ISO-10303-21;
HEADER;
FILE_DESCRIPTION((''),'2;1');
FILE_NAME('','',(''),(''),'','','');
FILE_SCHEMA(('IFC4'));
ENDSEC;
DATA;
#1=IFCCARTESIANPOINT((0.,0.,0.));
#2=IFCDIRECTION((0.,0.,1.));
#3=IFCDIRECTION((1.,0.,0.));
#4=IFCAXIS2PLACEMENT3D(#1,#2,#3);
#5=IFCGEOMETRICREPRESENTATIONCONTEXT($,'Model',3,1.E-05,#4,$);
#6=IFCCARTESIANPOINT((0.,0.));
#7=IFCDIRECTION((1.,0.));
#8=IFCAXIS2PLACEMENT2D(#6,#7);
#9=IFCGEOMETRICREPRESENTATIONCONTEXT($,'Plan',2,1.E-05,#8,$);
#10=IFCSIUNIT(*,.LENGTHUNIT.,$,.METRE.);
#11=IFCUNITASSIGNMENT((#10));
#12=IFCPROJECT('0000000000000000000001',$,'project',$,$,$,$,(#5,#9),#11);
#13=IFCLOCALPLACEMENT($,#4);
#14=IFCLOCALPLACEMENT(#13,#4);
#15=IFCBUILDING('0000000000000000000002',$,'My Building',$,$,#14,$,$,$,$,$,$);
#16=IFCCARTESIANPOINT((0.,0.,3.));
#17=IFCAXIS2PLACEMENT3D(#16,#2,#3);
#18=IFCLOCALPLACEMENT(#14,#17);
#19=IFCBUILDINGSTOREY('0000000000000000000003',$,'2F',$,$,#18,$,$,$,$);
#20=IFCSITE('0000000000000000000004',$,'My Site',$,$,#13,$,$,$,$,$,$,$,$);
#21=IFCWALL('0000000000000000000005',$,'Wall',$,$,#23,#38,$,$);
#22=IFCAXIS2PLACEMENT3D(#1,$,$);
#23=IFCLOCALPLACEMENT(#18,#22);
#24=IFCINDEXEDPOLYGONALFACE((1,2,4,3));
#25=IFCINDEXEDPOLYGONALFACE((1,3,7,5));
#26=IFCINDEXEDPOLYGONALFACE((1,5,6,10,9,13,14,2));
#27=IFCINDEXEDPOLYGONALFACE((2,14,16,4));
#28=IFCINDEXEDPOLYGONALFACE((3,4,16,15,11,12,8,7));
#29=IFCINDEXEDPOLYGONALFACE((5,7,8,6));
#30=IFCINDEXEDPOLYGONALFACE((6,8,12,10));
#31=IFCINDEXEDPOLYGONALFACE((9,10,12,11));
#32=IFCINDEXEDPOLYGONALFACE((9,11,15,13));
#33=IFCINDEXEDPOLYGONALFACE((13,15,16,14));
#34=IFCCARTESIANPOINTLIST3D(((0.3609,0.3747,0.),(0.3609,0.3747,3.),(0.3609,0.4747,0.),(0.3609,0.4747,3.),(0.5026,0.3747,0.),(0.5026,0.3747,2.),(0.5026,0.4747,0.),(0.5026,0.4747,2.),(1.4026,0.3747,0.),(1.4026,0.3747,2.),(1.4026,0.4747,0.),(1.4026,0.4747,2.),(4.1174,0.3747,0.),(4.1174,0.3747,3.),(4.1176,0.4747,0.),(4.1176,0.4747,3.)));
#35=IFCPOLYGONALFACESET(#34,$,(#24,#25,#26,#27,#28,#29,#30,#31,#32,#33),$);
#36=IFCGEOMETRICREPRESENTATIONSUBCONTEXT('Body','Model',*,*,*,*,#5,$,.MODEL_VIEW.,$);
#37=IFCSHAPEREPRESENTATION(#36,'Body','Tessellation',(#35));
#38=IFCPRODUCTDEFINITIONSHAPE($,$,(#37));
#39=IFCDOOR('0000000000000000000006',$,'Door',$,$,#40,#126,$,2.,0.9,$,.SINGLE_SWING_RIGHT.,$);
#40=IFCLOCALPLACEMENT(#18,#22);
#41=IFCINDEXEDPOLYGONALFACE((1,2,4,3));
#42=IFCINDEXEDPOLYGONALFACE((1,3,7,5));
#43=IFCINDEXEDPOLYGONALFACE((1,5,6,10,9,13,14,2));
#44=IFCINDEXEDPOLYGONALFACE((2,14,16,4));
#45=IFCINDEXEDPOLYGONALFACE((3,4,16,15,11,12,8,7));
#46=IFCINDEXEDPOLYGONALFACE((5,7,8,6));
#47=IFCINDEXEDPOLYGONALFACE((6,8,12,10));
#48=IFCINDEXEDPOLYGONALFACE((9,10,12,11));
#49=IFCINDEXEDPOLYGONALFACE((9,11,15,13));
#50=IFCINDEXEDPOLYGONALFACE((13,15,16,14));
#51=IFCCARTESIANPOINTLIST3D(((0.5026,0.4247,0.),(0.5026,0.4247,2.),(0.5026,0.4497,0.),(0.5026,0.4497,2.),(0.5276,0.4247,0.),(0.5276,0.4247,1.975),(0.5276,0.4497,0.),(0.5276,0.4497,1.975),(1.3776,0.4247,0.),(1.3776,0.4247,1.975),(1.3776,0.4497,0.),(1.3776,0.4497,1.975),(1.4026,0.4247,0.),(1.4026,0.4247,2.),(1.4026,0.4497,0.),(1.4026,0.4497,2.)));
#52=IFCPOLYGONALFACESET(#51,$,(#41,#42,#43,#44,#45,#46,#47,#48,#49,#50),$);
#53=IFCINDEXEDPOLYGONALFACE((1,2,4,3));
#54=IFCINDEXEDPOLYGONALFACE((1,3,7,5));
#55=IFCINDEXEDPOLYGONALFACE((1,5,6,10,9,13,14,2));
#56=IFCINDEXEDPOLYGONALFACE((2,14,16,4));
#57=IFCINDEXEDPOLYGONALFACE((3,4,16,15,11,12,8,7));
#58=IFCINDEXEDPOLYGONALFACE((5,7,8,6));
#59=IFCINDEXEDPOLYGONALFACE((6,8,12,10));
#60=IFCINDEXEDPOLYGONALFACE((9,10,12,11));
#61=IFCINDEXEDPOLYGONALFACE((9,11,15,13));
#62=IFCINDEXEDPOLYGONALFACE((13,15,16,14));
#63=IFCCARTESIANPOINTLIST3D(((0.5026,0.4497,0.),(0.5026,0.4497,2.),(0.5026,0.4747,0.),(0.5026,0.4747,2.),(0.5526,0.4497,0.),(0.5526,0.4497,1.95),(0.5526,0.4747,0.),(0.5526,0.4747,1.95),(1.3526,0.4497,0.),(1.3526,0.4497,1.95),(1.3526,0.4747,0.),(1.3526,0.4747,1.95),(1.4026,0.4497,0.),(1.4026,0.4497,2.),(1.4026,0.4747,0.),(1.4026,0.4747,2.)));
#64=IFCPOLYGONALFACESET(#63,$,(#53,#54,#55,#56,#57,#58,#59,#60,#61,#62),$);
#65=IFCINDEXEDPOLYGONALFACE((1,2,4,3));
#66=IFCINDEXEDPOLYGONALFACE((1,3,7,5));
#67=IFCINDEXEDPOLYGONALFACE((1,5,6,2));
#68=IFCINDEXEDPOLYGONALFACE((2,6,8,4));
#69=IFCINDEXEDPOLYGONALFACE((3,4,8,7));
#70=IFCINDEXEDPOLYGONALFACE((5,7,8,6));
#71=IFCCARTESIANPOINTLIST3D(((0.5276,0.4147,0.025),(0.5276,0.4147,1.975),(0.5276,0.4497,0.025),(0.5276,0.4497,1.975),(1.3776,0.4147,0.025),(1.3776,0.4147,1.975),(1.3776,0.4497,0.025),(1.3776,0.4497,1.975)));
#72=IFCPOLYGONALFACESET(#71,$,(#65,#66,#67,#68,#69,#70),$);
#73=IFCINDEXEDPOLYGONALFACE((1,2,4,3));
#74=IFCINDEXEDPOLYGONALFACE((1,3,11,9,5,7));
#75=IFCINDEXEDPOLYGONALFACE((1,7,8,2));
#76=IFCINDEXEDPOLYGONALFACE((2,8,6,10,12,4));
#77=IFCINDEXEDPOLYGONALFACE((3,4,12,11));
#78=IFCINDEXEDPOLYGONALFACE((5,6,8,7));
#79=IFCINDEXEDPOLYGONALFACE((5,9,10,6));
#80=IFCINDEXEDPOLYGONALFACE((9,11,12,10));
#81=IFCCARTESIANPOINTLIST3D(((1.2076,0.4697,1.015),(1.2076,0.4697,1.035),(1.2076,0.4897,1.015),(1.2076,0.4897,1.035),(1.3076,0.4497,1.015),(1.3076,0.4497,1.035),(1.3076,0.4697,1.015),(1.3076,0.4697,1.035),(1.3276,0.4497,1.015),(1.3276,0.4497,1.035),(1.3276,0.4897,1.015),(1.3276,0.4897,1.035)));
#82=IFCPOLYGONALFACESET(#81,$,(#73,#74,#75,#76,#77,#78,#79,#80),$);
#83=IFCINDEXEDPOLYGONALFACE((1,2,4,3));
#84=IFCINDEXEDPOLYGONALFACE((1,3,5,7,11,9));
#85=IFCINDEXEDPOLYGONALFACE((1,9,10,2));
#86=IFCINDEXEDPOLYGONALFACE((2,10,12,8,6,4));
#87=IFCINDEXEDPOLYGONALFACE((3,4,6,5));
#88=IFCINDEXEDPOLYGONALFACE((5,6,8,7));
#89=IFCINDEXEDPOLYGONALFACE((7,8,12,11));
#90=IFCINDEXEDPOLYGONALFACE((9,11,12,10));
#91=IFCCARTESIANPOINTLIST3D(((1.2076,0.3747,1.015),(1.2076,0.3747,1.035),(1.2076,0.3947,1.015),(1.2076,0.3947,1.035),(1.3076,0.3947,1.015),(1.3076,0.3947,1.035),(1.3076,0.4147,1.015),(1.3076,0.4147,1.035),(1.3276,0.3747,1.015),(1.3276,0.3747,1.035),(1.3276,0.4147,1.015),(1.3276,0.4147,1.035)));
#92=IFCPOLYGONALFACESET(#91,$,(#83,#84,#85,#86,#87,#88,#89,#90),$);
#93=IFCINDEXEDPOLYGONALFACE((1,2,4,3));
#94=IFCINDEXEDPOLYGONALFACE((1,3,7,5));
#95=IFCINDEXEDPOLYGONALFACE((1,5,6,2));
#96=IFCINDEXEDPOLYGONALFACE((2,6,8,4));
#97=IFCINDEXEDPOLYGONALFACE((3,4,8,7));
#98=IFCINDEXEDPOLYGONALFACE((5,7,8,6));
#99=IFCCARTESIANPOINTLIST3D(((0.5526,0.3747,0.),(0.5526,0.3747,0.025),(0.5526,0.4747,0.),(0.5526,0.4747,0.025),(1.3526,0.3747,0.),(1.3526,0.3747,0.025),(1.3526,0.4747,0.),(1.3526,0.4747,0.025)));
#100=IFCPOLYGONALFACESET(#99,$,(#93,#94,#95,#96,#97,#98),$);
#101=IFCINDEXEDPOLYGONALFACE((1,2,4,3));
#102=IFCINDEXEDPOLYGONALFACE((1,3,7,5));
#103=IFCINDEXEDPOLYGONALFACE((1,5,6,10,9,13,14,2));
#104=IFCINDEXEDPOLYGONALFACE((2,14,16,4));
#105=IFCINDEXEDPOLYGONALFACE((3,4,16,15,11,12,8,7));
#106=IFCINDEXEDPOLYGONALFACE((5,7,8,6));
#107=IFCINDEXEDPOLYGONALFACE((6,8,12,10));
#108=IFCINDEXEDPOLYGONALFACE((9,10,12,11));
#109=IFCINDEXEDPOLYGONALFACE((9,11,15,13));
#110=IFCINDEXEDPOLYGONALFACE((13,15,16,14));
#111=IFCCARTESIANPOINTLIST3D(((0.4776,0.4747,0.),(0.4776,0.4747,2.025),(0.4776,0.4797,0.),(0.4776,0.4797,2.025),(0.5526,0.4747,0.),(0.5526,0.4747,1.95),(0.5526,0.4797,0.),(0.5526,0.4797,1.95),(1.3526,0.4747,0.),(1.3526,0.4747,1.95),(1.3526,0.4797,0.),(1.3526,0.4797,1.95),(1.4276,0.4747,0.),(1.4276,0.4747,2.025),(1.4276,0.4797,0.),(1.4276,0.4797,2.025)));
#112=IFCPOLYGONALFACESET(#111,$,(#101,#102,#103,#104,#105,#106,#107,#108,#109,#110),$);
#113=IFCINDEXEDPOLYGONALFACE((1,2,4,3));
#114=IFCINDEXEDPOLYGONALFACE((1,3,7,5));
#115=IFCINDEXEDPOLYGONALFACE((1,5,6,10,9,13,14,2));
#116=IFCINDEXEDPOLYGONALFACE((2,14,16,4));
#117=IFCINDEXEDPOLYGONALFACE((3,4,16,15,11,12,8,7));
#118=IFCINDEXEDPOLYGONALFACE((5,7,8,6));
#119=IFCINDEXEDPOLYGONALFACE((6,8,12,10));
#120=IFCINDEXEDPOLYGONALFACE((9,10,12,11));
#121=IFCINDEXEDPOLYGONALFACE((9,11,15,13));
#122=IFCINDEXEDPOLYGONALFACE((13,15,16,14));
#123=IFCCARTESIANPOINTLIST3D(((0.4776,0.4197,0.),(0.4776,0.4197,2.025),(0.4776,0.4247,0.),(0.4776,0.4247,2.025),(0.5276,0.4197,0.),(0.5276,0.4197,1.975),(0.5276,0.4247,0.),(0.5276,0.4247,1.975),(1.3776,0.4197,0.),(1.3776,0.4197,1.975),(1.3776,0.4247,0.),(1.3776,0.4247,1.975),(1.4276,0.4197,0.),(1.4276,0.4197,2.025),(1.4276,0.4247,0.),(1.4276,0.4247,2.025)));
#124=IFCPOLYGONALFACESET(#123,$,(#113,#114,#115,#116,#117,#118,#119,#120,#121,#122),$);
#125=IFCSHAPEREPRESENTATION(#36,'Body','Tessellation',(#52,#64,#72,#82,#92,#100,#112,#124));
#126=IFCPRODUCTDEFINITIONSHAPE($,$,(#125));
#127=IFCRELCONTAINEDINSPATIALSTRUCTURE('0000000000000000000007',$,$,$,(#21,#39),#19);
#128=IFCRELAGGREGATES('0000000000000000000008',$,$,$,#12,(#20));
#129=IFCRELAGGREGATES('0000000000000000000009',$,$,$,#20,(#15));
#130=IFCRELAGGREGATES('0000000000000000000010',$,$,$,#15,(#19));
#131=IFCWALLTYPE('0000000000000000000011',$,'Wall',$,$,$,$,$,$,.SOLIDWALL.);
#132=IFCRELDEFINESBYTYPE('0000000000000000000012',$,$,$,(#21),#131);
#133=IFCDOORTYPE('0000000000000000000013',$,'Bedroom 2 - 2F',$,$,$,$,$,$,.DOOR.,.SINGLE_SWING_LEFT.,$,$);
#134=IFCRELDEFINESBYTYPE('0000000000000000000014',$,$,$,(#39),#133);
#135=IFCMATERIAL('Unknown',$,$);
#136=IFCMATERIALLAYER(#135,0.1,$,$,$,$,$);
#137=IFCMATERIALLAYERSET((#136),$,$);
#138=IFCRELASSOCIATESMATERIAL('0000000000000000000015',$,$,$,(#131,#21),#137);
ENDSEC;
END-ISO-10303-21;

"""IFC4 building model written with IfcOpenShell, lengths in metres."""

from ifc_helpers import new_model, entity, si_unit, frame, origin_with_axes, origin_2d_with_axis, place, context, subcontext, project, spatial, line, indexed_curve, outline, extrude, shape, source, transform, mapped, material, layer, layer_set, layer_usage, type_object, type_shapes, element, fill, save


model = new_model("IFC4")

# Units and contexts
model_context = context("Model", 3, precision=1e-05, world=origin_with_axes())
plan_context = context("Plan", 2, precision=1e-05, world=origin_2d_with_axis())
body_context_1 = subcontext(model_context, "Body", "Model", "MODEL_VIEW")
body_context_2 = subcontext(plan_context, "Body", "Plan", "PLAN_VIEW")
ifc_project = project(units=[si_unit("LENGTHUNIT", "METRE")], contexts=[model_context, plan_context])

# Site, building, storey
site_placement = place(None, origin_with_axes())
site = spatial("IfcSite", under=ifc_project, at=site_placement, Name="My Site")
building_placement = place(site_placement, origin_with_axes())
building = spatial("IfcBuilding", under=site, at=building_placement, Name="My Building")
storey_placement = place(building_placement, frame((0.0, 0.0, 3.0), z_axis=(0.0, 0.0, 1.0), x_axis=(1.0, 0.0, 0.0)))
storey = spatial("IfcBuildingStorey", under=building, at=storey_placement, Name="2F")

# Shared definitions
ifc_material = material(Name="Unknown")

# Shared definitions
ifc_layer = layer(ifc_material, 0.1)
ifc_layer_set = layer_set([ifc_layer])
wall_type = type_object("IfcWallType", Name="Wall", PredefinedType="SOLIDWALL", material=ifc_layer_set)

# Wall, opening, door
ifc_layer_usage_1 = layer_usage(ifc_layer_set, "AXIS2", "POSITIVE", 0.0)
wall_1_placement = place(storey_placement, frame((0.2609, 0.3747, 0.0), z_axis=(0.0, 0.0, 1.0), x_axis=(1.0, 0.0, 0.0)))
wall_1 = element("IfcWall", 1, at=wall_1_placement, inside=storey, type_object=wall_type, material=ifc_layer_usage_1, Name="Wall", context=body_context_1, shape_type="SweptSolid", body=[
    extrude(outline(indexed_curve([(0.1, 0.0), (0.1, 0.1), (3.8567, 0.1), (3.8565, 0.0)], segments=[line(1, 2, 3, 4, 1)])), origin_with_axes(), (0.0, 0.0, 1.0), 3.0),
])
shared_shape_1 = source(origin_with_axes(), body_context_1, "Body", "SweptSolid", [
    extrude(outline(indexed_curve([(0.0, 0.0), (0.9, 0.0), (0.9, 2.0), (0.0, 2.0)], segments=[line(1, 2, 3, 4, 1)])), frame((0.0, -0.6, 0.0), z_axis=(0.0, -1.0, 0.0), x_axis=(1.0, 0.0, 0.0)), (0.0, 0.0, -1.0), 1.2),
])
opening_1_placement = place(wall_1_placement, frame((1.1417, 0.1, 0.0), z_axis=(0.0, 0.0, 1.0), x_axis=(-1.0, 0.0, 0.0)))
opening_1 = element("IfcOpeningElement", 2, at=opening_1_placement, cuts=wall_1, PredefinedType="OPENING", context=body_context_1, shape_type="MappedRepresentation", body=[
    mapped(shared_shape_1, transform((0.0, 0.0, 0.0), x_axis=(1.0, 0.0, 0.0), y_axis=(0.0, 1.0, 0.0), z_axis=(0.0, 0.0, 1.0), scale=1.0)),
])
door_type_1 = type_object("IfcDoorType", Name="Bedroom 2 - 2F", OperationType="SINGLE_SWING_LEFT", PredefinedType="DOOR")
shared_shape_2 = source(origin_with_axes(), body_context_1, "Body", "SweptSolid", [
    extrude(outline(indexed_curve([(0.0, 0.0), (0.0, 2.0), (0.9, 2.0), (0.9, 0.0), (0.875, 0.0), (0.875, 1.975), (0.025, 1.975), (0.025, 0.0)], segments=[line(1, 2, 3, 4, 5, 6, 7, 8, 1)])), frame((0.0, 0.025, 0.0), z_axis=(0.0, -1.0, 0.0), x_axis=(1.0, 0.0, 0.0)), (0.0, 0.0, -1.0), 0.025),
    extrude(outline(indexed_curve([(0.0, 0.0), (0.0, 2.0), (0.9, 2.0), (0.9, 0.0), (0.85, 0.0), (0.85, 1.95), (0.05, 1.95), (0.05, 0.0)], segments=[line(1, 2, 3, 4, 5, 6, 7, 8, 1)])), frame((0.0, 0.0, 0.0), z_axis=(0.0, -1.0, 0.0), x_axis=(1.0, 0.0, 0.0)), (0.0, 0.0, -1.0), 0.025),
    extrude(outline(indexed_curve([(0.0, 0.0), (0.85, 0.0), (0.85, 0.035), (0.0, 0.035)], segments=[line(1, 2, 3, 4, 1)])), frame((0.025, 0.025, 0.025), z_axis=(0.0, 0.0, 1.0), x_axis=(1.0, 0.0, 0.0)), (0.0, 0.0, 1.0), 1.95),
    extrude(outline(indexed_curve([(0.0, 0.0), (0.0, -0.04), (0.12, -0.04), (0.12, -0.02), (0.02, -0.02), (0.02, 0.0)], segments=[line(1, 2, 3, 4, 5, 6, 1)])), frame((0.075, 0.025, 1.015), z_axis=(0.0, 0.0, 1.0), x_axis=(1.0, 0.0, 0.0)), (0.0, 0.0, 1.0), 0.02),
    extrude(outline(indexed_curve([(0.0, 0.0), (0.0, 0.04), (0.12, 0.04), (0.12, 0.02), (0.02, 0.02), (0.02, 0.0)], segments=[line(1, 2, 3, 4, 5, 6, 1)])), frame((0.075, 0.06, 1.015), z_axis=(0.0, 0.0, 1.0), x_axis=(1.0, 0.0, 0.0)), (0.0, 0.0, 1.0), 0.02),
    extrude(outline(indexed_curve([(0.0, 0.0), (0.8, 0.0), (0.8, 0.1), (0.0, 0.1)], segments=[line(1, 2, 3, 4, 1)])), frame((0.05, 0.0, 0.0), z_axis=(0.0, 0.0, 1.0), x_axis=(1.0, 0.0, 0.0)), (0.0, 0.0, 1.0), 0.025),
    extrude(outline(indexed_curve([(0.0, 0.0), (0.0, 2.025), (0.95, 2.025), (0.95, 0.0), (0.875, 0.0), (0.875, 1.95), (0.075, 1.95), (0.075, 0.0)], segments=[line(1, 2, 3, 4, 5, 6, 7, 8, 1)])), frame((-0.025, -0.005, 0.0), z_axis=(0.0, -1.0, 0.0), x_axis=(1.0, 0.0, 0.0)), (0.0, 0.0, -1.0), 0.005),
    extrude(outline(indexed_curve([(0.0, 0.0), (0.0, 2.025), (0.95, 2.025), (0.95, 0.0), (0.9, 0.0), (0.9, 1.975), (0.05, 1.975), (0.05, 0.0)], segments=[line(1, 2, 3, 4, 5, 6, 7, 8, 1)])), frame((-0.025, 0.05, 0.0), z_axis=(0.0, -1.0, 0.0), x_axis=(1.0, 0.0, 0.0)), (0.0, 0.0, -1.0), 0.005),
])
shared_shape_3 = source(origin_with_axes(), body_context_2, "Body", "Curve2D", [
    entity("IfcIndexedPolyCurve", entity("IfcCartesianPointList2D", [[0.0, 0.0], [0.0, 0.05], [0.025, 0.05], [0.025, 0.025], [0.05, 0.025], [0.05, 0.0]]), [entity("IfcLineIndex", [1, 2, 3, 4, 5, 6, 1])]),
    entity("IfcIndexedPolyCurve", entity("IfcCartesianPointList2D", [[0.9, 0.0], [0.9, 0.05], [0.875, 0.05], [0.875, 0.025], [0.85, 0.025], [0.85, 0.0]]), [entity("IfcLineIndex", [1, 2, 3, 4, 5, 6, 1])]),
    entity("IfcTrimmedCurve", entity("IfcEllipse", entity("IfcAxis2Placement2D", entity("IfcCartesianPoint", [0.84, 0.05]), entity("IfcDirection", [1.0, 0.0])), 0.815, 0.85), [entity("IfcCartesianPoint", [0.84, 0.9])], [entity("IfcCartesianPoint", [0.025, 0.05])], True, "CARTESIAN"),
    entity("IfcIndexedPolyCurve", entity("IfcCartesianPointList2D", [[0.875, 0.05], [0.84, 0.05], [0.84, 0.9], [0.875, 0.9]]), [entity("IfcLineIndex", [1, 2, 3, 4, 1])]),
])
type_shapes(door_type_1, [shared_shape_2, shared_shape_3])
door_1_placement = place(opening_1_placement, origin_with_axes())
door_1 = element("IfcDoor", 3, at=door_1_placement, inside=storey, type_object=door_type_1, Name="Door", OperationType="SINGLE_SWING_RIGHT", OverallHeight=2.0, OverallWidth=0.9, shapes=[
    shape(body_context_1, "Body", "MappedRepresentation", [mapped(shared_shape_2, transform((0.0, 0.0, 0.0), x_axis=(1.0, 0.0, 0.0), y_axis=(0.0, 1.0, 0.0), z_axis=(0.0, 0.0, 1.0), scale=1.0))]),
    shape(body_context_2, "Body", "MappedRepresentation", [mapped(shared_shape_3, transform((0.0, 0.0, 0.0), x_axis=(1.0, 0.0, 0.0), y_axis=(0.0, 1.0, 0.0), z_axis=(0.0, 0.0, 1.0), scale=1.0))]),
])
fill(opening_1, door_1)

save(model, "model.ifc")
